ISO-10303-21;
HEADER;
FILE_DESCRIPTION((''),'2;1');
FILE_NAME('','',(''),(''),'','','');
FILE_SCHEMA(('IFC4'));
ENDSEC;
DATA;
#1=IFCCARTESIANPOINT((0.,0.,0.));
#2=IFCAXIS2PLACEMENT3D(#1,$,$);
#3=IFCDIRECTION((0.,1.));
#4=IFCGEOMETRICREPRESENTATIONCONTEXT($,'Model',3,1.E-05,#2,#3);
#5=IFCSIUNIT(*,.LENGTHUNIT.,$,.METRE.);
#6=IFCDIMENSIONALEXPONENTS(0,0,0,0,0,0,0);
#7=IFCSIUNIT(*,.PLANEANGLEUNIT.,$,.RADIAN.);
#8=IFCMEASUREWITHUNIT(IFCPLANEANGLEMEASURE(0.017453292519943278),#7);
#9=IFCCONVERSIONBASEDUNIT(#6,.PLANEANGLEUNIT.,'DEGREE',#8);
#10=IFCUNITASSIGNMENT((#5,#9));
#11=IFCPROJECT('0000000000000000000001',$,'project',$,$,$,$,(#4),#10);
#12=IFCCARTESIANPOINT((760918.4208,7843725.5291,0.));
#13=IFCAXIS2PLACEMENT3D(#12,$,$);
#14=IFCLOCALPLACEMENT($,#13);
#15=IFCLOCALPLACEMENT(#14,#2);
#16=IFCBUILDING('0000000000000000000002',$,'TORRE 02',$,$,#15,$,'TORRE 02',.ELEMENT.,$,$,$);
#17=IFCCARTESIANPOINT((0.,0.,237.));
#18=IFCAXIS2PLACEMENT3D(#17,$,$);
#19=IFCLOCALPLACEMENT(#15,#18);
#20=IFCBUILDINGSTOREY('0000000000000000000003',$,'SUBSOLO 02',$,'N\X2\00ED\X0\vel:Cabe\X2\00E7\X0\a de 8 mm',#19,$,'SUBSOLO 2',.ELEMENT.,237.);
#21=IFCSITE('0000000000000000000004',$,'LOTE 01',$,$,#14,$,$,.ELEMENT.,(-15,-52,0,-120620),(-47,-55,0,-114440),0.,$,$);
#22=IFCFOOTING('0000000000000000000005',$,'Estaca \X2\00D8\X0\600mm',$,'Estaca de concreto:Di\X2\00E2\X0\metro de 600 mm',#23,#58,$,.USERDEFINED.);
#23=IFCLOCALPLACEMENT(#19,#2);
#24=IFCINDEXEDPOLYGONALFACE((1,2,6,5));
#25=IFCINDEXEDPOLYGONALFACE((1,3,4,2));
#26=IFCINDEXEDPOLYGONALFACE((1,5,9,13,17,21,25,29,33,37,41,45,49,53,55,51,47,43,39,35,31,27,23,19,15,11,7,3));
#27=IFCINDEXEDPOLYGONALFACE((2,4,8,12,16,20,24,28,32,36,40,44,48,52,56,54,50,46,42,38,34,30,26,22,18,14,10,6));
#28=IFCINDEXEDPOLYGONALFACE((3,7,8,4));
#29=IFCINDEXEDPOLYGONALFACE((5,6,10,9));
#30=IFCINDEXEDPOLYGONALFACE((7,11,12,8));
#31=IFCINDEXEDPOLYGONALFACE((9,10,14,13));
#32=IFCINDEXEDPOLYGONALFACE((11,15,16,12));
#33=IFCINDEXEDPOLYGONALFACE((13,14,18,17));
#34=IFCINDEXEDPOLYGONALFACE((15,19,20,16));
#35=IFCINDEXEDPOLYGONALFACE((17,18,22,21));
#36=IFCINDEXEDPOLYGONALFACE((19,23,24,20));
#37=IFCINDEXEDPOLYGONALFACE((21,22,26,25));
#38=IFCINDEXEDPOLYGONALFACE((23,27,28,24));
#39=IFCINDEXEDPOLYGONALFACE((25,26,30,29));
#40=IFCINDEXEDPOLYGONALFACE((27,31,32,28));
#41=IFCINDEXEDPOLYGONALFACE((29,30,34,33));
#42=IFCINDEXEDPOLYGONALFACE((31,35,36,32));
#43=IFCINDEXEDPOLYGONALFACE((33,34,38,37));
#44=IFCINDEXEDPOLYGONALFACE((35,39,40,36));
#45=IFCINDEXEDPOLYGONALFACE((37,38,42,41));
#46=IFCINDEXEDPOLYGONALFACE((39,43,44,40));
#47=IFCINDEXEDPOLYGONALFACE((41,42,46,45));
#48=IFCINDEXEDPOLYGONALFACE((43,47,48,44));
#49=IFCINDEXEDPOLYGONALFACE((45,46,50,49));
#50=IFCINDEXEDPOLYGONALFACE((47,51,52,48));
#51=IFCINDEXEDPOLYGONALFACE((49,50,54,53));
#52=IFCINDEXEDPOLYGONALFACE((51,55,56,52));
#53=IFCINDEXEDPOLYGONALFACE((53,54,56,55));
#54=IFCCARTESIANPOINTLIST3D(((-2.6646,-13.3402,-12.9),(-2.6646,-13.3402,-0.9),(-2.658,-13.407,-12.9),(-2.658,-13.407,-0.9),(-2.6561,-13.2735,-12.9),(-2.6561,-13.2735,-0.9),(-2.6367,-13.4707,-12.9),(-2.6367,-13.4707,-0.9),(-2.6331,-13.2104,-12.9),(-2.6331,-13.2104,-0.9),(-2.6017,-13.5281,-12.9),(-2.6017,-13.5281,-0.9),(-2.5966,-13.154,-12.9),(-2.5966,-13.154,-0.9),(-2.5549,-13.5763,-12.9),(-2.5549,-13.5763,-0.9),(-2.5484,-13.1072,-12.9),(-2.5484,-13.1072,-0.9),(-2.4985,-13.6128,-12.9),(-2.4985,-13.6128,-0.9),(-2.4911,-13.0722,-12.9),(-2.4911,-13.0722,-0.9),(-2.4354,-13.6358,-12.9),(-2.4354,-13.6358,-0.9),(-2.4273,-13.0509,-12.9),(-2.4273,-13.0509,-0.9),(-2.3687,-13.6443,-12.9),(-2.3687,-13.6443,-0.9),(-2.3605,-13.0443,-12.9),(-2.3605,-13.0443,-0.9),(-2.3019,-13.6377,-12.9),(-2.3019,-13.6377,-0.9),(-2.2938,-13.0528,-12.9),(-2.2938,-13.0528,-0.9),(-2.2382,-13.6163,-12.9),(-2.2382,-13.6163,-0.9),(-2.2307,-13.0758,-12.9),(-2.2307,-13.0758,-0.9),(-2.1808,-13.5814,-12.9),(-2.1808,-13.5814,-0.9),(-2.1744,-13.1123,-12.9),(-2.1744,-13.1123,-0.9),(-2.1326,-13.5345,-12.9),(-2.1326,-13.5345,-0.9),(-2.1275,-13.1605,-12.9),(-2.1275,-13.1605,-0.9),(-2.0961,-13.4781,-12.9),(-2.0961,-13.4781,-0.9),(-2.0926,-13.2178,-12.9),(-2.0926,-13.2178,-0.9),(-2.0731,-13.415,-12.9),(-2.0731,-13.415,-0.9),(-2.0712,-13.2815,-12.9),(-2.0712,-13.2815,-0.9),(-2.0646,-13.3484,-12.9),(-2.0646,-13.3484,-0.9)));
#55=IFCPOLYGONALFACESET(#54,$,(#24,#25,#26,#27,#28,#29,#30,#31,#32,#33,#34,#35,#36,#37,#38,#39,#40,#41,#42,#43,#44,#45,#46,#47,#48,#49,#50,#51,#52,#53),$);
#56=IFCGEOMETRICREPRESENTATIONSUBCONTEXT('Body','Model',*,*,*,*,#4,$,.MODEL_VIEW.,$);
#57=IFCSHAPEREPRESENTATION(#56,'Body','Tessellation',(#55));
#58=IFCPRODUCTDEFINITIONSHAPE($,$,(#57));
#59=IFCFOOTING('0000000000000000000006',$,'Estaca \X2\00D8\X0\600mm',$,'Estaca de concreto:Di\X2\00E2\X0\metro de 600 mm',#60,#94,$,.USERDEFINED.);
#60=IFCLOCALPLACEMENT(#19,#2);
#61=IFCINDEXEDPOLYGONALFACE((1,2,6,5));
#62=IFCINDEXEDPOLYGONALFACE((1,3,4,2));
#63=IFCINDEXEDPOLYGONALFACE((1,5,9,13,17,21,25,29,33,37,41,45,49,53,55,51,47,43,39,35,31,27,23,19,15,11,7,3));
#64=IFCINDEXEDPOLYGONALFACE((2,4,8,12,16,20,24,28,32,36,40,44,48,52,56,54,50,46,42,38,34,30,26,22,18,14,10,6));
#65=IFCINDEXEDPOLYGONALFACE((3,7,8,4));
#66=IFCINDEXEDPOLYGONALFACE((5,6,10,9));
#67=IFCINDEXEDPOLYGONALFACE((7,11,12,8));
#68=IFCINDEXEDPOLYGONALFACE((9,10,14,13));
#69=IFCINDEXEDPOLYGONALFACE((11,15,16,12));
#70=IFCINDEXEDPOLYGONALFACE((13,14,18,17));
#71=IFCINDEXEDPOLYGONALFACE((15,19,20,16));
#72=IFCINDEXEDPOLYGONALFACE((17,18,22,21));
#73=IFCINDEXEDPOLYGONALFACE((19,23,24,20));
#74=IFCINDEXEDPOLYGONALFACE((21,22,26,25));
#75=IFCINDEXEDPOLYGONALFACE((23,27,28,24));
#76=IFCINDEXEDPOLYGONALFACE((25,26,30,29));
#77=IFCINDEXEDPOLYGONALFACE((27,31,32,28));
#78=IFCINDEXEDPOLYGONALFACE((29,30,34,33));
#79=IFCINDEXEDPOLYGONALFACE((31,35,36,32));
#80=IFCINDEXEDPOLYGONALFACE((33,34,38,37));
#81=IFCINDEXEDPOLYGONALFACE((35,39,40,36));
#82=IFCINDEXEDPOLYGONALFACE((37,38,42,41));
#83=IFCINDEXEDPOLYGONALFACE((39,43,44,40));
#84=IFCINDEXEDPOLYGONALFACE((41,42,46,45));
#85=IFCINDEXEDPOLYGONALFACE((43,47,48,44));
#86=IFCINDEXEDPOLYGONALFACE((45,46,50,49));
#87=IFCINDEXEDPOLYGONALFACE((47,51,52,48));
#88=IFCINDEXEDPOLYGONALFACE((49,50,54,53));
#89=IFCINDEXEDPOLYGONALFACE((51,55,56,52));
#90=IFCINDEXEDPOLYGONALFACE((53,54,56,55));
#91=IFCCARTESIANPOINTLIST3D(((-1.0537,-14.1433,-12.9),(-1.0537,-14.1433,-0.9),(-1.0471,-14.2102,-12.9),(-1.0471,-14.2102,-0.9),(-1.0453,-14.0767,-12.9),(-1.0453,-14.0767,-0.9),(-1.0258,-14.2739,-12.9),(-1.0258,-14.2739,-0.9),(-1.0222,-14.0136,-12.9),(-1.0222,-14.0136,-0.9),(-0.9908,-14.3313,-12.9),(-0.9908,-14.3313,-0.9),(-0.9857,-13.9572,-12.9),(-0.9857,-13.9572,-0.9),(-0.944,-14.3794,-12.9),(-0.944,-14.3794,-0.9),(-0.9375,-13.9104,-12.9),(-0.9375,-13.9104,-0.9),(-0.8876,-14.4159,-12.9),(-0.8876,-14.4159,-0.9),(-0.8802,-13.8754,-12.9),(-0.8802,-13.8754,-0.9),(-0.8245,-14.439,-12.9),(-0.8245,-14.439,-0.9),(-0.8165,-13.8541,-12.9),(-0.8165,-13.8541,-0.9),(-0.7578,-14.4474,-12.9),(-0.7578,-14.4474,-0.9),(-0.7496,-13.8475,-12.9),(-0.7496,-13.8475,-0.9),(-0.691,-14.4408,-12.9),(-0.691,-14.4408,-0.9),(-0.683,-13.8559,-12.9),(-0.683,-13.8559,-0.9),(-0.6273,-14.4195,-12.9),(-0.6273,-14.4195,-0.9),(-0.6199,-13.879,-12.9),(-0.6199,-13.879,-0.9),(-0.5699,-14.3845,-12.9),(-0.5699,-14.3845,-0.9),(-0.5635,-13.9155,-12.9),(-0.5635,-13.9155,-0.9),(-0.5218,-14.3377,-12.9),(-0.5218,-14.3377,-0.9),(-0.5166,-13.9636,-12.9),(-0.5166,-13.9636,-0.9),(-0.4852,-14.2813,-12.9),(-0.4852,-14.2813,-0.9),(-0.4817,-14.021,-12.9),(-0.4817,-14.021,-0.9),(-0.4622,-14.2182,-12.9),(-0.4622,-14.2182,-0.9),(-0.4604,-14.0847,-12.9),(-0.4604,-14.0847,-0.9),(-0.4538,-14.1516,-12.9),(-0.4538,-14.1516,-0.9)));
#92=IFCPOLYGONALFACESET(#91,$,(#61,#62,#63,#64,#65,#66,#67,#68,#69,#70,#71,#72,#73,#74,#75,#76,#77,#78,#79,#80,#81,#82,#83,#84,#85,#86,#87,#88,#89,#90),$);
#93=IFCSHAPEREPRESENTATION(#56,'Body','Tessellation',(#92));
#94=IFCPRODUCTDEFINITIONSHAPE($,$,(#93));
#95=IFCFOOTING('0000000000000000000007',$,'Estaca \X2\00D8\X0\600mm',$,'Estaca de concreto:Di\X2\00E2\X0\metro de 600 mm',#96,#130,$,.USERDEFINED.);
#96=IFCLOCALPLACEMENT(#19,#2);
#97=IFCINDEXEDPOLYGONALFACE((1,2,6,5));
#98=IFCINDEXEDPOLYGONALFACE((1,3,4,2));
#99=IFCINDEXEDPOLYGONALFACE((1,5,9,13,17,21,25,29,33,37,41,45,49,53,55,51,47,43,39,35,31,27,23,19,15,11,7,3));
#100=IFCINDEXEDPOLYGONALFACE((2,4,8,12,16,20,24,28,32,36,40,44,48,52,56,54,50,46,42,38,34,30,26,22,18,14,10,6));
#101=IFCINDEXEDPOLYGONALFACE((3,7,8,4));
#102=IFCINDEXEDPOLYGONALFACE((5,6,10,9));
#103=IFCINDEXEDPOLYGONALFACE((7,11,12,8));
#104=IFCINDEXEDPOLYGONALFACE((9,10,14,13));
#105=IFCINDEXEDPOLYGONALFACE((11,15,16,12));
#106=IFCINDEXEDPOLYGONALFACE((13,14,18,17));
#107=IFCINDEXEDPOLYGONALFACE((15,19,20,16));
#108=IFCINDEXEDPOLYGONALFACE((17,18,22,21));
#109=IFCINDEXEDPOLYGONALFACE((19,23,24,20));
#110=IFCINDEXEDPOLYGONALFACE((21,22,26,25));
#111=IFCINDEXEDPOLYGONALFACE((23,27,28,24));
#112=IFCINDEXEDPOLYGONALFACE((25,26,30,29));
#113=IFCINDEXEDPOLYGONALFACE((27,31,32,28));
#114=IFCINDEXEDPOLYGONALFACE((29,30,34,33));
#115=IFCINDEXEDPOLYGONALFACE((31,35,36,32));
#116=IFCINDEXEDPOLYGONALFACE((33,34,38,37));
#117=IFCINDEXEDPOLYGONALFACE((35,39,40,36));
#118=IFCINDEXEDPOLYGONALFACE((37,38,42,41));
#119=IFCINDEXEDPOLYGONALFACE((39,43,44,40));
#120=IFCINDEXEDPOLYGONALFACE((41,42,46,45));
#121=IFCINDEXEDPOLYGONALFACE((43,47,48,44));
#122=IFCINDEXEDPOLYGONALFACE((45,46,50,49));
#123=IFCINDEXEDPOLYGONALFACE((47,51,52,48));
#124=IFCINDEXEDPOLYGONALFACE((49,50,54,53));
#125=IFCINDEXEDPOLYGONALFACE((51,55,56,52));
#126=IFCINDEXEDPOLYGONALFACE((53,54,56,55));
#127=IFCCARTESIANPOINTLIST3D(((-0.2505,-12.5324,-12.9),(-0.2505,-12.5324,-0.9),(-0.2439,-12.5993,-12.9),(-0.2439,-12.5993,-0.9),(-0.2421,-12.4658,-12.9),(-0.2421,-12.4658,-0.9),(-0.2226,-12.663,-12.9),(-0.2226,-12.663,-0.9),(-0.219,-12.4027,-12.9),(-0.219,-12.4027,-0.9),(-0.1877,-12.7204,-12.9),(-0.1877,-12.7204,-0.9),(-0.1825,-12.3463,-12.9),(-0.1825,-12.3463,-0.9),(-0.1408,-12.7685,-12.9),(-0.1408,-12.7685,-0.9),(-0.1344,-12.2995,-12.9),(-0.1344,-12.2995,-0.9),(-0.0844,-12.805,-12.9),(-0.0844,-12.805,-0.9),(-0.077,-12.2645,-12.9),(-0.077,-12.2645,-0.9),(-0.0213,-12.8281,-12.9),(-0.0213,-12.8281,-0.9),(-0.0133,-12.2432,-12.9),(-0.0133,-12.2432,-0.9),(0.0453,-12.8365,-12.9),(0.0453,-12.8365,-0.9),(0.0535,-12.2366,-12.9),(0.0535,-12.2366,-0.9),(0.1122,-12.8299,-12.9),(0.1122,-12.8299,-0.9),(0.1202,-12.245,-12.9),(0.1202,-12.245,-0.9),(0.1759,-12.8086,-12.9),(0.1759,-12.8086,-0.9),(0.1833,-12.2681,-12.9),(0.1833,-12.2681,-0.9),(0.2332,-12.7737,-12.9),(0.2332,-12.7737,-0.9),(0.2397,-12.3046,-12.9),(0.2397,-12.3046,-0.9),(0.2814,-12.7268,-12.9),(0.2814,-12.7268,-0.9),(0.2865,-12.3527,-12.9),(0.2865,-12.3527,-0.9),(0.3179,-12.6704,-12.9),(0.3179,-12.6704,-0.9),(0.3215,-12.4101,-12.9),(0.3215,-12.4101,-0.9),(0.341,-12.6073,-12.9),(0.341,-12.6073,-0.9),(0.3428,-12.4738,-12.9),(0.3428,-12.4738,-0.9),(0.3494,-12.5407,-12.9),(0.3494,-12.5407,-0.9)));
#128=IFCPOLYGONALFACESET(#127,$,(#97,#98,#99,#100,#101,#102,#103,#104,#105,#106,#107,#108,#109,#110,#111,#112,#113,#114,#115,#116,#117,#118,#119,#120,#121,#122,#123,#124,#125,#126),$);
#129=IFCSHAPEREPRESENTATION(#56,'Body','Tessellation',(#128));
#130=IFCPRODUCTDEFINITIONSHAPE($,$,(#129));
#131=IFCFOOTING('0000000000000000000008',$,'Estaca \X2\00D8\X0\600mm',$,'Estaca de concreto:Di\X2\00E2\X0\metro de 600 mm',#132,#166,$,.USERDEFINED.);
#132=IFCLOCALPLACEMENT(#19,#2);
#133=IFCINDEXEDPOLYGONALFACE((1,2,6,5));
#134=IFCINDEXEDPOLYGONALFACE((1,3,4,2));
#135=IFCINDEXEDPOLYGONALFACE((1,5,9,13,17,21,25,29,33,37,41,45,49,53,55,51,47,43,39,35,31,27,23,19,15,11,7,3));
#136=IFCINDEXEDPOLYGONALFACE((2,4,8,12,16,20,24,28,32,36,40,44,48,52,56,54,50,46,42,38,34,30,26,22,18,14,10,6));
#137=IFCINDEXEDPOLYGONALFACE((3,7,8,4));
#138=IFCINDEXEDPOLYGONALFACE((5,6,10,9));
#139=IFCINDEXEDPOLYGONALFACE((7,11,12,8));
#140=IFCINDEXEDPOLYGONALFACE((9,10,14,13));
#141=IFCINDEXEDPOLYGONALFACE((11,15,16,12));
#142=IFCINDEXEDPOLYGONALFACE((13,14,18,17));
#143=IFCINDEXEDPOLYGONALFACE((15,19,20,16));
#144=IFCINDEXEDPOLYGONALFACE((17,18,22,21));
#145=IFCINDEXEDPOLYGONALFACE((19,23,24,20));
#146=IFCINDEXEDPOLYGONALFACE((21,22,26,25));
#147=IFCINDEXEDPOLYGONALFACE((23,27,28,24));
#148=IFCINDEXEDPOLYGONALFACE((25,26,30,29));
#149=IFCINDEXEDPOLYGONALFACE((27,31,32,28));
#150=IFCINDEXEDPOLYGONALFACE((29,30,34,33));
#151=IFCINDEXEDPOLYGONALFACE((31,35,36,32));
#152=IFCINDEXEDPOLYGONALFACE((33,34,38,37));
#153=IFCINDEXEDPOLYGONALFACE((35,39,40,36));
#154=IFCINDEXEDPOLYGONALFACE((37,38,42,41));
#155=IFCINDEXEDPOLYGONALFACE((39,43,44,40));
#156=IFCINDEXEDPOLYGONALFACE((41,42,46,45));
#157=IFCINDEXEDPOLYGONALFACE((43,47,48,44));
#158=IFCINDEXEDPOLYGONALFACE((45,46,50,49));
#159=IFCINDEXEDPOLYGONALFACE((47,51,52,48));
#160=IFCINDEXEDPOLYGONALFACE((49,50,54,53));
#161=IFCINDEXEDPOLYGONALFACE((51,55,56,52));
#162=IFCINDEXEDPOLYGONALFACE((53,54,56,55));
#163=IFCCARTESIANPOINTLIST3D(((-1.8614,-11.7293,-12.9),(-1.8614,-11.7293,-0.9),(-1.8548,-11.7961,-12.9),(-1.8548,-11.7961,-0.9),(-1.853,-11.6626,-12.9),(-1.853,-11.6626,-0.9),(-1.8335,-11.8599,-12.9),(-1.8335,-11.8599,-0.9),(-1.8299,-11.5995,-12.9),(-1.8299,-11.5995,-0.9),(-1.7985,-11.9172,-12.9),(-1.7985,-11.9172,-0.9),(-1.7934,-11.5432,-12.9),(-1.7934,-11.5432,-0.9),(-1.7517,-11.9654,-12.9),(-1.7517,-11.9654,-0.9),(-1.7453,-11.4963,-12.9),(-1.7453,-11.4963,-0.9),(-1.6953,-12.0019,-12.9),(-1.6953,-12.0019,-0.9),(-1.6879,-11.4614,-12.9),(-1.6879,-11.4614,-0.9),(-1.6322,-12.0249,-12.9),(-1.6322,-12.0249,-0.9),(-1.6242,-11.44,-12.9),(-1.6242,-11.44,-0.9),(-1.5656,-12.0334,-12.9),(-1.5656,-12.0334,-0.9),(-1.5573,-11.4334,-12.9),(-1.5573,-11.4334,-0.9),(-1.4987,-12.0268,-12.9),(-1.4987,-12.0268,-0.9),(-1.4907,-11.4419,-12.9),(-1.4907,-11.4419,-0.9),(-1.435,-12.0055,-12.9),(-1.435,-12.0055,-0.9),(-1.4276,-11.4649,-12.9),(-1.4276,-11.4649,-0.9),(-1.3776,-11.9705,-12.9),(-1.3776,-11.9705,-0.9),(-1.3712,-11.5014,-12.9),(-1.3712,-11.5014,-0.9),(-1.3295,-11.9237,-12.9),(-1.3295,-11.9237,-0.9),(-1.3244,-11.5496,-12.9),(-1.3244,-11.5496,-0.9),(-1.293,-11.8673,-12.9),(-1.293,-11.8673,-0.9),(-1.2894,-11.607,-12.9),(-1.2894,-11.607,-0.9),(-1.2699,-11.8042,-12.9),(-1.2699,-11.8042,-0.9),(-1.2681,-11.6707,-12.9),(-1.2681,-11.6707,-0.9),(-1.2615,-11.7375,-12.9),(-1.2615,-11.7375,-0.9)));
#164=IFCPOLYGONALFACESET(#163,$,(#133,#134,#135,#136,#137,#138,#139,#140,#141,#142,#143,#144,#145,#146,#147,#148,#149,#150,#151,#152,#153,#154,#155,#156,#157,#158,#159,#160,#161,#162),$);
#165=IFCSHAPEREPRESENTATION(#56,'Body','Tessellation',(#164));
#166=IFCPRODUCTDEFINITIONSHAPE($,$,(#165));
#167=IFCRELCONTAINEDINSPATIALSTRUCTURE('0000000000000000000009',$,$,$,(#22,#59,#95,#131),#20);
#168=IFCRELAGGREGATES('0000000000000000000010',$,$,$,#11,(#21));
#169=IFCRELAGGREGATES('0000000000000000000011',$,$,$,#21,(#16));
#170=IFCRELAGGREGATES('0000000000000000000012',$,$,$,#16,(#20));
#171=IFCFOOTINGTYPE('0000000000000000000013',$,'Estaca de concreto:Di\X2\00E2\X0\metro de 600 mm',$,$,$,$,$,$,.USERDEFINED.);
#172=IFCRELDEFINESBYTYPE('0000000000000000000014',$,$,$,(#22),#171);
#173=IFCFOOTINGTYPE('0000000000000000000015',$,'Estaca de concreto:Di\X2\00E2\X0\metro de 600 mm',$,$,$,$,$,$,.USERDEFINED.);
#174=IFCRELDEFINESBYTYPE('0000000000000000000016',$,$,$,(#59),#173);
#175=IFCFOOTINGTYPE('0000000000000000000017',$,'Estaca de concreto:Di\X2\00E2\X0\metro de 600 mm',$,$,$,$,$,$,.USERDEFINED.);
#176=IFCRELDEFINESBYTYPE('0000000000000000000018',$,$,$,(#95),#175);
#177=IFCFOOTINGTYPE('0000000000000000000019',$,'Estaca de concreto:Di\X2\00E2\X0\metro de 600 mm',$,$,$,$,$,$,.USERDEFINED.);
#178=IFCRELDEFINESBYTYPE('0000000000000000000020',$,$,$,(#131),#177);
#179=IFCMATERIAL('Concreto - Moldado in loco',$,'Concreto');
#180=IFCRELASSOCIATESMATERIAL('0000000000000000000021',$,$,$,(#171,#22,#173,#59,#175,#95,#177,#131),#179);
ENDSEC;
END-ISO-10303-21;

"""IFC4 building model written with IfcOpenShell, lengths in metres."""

from ifc_helpers import new_model, entity, si_unit, converted_unit, direction, frame, origin, place, context, subcontext, project, spatial, arc, indexed_curve, outline, extrude, source, transform, mapped, material, type_object, type_shapes, element, save


model = new_model("IFC4")

# Units and contexts
model_context = context("Model", 3, precision=1e-05, world=origin(), true_north=direction((0.0, 1.0)))
body_context = subcontext(model_context, "Body", "Model", "MODEL_VIEW")
ifc_project = project(units=[si_unit("LENGTHUNIT", "METRE"), converted_unit("PLANEANGLEUNIT", "DEGREE", entity("IfcPlaneAngleMeasure", 0.017453292519943278), si_unit("PLANEANGLEUNIT", "RADIAN"), dimensions=[0, 0, 0, 0, 0, 0, 0])], contexts=[model_context])

# Site, building, storey
site_placement = place(None, frame((760918.4208, 7843725.5291, 0.0)))
site = spatial("IfcSite", under=ifc_project, at=site_placement, Name="LOTE 01", CompositionType="ELEMENT", RefLatitude=(-15, -52, 0, -120620), RefLongitude=(-47, -55, 0, -114440), RefElevation=0.0)
building_placement = place(site_placement, origin())
building = spatial("IfcBuilding", under=site, at=building_placement, Name="TORRE 02", LongName="TORRE 02", CompositionType="ELEMENT")
storey_placement = place(building_placement, frame((0.0, 0.0, 237.0)))
storey = spatial("IfcBuildingStorey", under=building, at=storey_placement, Name="SUBSOLO 02", ObjectType="Nível:Cabeça de 8 mm", LongName="SUBSOLO 2", CompositionType="ELEMENT", Elevation=237.0)

# Footings
ifc_material_1 = material(Name="Concreto - Moldado in loco", Category="Concreto")
placement = place(building_placement, frame((0.0, 0.0, 237.0)))
footing_type_1 = type_object("IfcFootingType", Name="Estaca de concreto:Diâmetro de 600 mm", PredefinedType="USERDEFINED", material=ifc_material_1)
shared_shape_1 = source(origin(), body_context, "Body", "SweptSolid", [
    extrude(outline(indexed_curve([(-0.3, 0.0), (0.0, -0.3), (0.3, 0.0), (0.0, 0.3)], segments=[arc(1, 2, 3), arc(3, 4, 1)], self_intersect=False)), frame((-2.3646, -13.3443, -12.0), z_axis=(0.0, 0.0, 1.0), x_axis=(0.894934, -0.446198, 0.0)), (0.0, 0.0, 1.0), 12.0),
])
type_shapes(footing_type_1, [shared_shape_1])
footing_1_placement = place(placement, frame((0.0, 0.0, -0.9)))
element("IfcFooting", 1, at=footing_1_placement, inside=storey, type_object=footing_type_1, material=ifc_material_1, Name="Estaca Ø600mm", ObjectType="Estaca de concreto:Diâmetro de 600 mm", PredefinedType="USERDEFINED", context=body_context, shape_type="MappedRepresentation", body=[
    mapped(shared_shape_1, transform((0.0, 0.0, 0.0), scale=1.0)),
])
footing_type_2 = type_object("IfcFootingType", Name="Estaca de concreto:Diâmetro de 600 mm", PredefinedType="USERDEFINED", material=ifc_material_1)
shared_shape_2 = source(origin(), body_context, "Body", "SweptSolid", [
    extrude(outline(indexed_curve([(-0.3, 0.0), (0.0, -0.3), (0.3, 0.0), (0.0, 0.3)], segments=[arc(1, 2, 3), arc(3, 4, 1)], self_intersect=False)), frame((-0.7537, -14.1474, -12.0), z_axis=(0.0, 0.0, 1.0), x_axis=(0.894934, -0.446198, 0.0)), (0.0, 0.0, 1.0), 12.0),
])
type_shapes(footing_type_2, [shared_shape_2])
footing_2_placement = place(placement, frame((0.0, 0.0, -0.9)))
element("IfcFooting", 2, at=footing_2_placement, inside=storey, type_object=footing_type_2, material=ifc_material_1, Name="Estaca Ø600mm", ObjectType="Estaca de concreto:Diâmetro de 600 mm", PredefinedType="USERDEFINED", context=body_context, shape_type="MappedRepresentation", body=[
    mapped(shared_shape_2, transform((0.0, 0.0, 0.0), scale=1.0)),
])
footing_type_3 = type_object("IfcFootingType", Name="Estaca de concreto:Diâmetro de 600 mm", PredefinedType="USERDEFINED", material=ifc_material_1)
shared_shape_3 = source(origin(), body_context, "Body", "SweptSolid", [
    extrude(outline(indexed_curve([(-0.3, 0.0), (0.0, -0.3), (0.3, 0.0), (0.0, 0.3)], segments=[arc(1, 2, 3), arc(3, 4, 1)], self_intersect=False)), frame((0.0494, -12.5366, -12.0), z_axis=(0.0, 0.0, 1.0), x_axis=(0.894934, -0.446198, 0.0)), (0.0, 0.0, 1.0), 12.0),
])
type_shapes(footing_type_3, [shared_shape_3])
footing_3_placement = place(placement, frame((0.0, 0.0, -0.9)))
element("IfcFooting", 3, at=footing_3_placement, inside=storey, type_object=footing_type_3, material=ifc_material_1, Name="Estaca Ø600mm", ObjectType="Estaca de concreto:Diâmetro de 600 mm", PredefinedType="USERDEFINED", context=body_context, shape_type="MappedRepresentation", body=[
    mapped(shared_shape_3, transform((0.0, 0.0, 0.0), scale=1.0)),
])
footing_type_4 = type_object("IfcFootingType", Name="Estaca de concreto:Diâmetro de 600 mm", PredefinedType="USERDEFINED", material=ifc_material_1)
shared_shape_4 = source(origin(), body_context, "Body", "SweptSolid", [
    extrude(outline(indexed_curve([(-0.3, 0.0), (0.0, -0.3), (0.3, 0.0), (0.0, 0.3)], segments=[arc(1, 2, 3), arc(3, 4, 1)], self_intersect=False)), frame((-1.5614, -11.7334, -12.0), z_axis=(0.0, 0.0, 1.0), x_axis=(0.894934, -0.446198, 0.0)), (0.0, 0.0, 1.0), 12.0),
])
type_shapes(footing_type_4, [shared_shape_4])
footing_4_placement = place(placement, frame((0.0, 0.0, -0.9)))
element("IfcFooting", 4, at=footing_4_placement, inside=storey, type_object=footing_type_4, material=ifc_material_1, Name="Estaca Ø600mm", ObjectType="Estaca de concreto:Diâmetro de 600 mm", PredefinedType="USERDEFINED", context=body_context, shape_type="MappedRepresentation", body=[
    mapped(shared_shape_4, transform((0.0, 0.0, 0.0), scale=1.0)),
])

save(model, "model.ifc")
